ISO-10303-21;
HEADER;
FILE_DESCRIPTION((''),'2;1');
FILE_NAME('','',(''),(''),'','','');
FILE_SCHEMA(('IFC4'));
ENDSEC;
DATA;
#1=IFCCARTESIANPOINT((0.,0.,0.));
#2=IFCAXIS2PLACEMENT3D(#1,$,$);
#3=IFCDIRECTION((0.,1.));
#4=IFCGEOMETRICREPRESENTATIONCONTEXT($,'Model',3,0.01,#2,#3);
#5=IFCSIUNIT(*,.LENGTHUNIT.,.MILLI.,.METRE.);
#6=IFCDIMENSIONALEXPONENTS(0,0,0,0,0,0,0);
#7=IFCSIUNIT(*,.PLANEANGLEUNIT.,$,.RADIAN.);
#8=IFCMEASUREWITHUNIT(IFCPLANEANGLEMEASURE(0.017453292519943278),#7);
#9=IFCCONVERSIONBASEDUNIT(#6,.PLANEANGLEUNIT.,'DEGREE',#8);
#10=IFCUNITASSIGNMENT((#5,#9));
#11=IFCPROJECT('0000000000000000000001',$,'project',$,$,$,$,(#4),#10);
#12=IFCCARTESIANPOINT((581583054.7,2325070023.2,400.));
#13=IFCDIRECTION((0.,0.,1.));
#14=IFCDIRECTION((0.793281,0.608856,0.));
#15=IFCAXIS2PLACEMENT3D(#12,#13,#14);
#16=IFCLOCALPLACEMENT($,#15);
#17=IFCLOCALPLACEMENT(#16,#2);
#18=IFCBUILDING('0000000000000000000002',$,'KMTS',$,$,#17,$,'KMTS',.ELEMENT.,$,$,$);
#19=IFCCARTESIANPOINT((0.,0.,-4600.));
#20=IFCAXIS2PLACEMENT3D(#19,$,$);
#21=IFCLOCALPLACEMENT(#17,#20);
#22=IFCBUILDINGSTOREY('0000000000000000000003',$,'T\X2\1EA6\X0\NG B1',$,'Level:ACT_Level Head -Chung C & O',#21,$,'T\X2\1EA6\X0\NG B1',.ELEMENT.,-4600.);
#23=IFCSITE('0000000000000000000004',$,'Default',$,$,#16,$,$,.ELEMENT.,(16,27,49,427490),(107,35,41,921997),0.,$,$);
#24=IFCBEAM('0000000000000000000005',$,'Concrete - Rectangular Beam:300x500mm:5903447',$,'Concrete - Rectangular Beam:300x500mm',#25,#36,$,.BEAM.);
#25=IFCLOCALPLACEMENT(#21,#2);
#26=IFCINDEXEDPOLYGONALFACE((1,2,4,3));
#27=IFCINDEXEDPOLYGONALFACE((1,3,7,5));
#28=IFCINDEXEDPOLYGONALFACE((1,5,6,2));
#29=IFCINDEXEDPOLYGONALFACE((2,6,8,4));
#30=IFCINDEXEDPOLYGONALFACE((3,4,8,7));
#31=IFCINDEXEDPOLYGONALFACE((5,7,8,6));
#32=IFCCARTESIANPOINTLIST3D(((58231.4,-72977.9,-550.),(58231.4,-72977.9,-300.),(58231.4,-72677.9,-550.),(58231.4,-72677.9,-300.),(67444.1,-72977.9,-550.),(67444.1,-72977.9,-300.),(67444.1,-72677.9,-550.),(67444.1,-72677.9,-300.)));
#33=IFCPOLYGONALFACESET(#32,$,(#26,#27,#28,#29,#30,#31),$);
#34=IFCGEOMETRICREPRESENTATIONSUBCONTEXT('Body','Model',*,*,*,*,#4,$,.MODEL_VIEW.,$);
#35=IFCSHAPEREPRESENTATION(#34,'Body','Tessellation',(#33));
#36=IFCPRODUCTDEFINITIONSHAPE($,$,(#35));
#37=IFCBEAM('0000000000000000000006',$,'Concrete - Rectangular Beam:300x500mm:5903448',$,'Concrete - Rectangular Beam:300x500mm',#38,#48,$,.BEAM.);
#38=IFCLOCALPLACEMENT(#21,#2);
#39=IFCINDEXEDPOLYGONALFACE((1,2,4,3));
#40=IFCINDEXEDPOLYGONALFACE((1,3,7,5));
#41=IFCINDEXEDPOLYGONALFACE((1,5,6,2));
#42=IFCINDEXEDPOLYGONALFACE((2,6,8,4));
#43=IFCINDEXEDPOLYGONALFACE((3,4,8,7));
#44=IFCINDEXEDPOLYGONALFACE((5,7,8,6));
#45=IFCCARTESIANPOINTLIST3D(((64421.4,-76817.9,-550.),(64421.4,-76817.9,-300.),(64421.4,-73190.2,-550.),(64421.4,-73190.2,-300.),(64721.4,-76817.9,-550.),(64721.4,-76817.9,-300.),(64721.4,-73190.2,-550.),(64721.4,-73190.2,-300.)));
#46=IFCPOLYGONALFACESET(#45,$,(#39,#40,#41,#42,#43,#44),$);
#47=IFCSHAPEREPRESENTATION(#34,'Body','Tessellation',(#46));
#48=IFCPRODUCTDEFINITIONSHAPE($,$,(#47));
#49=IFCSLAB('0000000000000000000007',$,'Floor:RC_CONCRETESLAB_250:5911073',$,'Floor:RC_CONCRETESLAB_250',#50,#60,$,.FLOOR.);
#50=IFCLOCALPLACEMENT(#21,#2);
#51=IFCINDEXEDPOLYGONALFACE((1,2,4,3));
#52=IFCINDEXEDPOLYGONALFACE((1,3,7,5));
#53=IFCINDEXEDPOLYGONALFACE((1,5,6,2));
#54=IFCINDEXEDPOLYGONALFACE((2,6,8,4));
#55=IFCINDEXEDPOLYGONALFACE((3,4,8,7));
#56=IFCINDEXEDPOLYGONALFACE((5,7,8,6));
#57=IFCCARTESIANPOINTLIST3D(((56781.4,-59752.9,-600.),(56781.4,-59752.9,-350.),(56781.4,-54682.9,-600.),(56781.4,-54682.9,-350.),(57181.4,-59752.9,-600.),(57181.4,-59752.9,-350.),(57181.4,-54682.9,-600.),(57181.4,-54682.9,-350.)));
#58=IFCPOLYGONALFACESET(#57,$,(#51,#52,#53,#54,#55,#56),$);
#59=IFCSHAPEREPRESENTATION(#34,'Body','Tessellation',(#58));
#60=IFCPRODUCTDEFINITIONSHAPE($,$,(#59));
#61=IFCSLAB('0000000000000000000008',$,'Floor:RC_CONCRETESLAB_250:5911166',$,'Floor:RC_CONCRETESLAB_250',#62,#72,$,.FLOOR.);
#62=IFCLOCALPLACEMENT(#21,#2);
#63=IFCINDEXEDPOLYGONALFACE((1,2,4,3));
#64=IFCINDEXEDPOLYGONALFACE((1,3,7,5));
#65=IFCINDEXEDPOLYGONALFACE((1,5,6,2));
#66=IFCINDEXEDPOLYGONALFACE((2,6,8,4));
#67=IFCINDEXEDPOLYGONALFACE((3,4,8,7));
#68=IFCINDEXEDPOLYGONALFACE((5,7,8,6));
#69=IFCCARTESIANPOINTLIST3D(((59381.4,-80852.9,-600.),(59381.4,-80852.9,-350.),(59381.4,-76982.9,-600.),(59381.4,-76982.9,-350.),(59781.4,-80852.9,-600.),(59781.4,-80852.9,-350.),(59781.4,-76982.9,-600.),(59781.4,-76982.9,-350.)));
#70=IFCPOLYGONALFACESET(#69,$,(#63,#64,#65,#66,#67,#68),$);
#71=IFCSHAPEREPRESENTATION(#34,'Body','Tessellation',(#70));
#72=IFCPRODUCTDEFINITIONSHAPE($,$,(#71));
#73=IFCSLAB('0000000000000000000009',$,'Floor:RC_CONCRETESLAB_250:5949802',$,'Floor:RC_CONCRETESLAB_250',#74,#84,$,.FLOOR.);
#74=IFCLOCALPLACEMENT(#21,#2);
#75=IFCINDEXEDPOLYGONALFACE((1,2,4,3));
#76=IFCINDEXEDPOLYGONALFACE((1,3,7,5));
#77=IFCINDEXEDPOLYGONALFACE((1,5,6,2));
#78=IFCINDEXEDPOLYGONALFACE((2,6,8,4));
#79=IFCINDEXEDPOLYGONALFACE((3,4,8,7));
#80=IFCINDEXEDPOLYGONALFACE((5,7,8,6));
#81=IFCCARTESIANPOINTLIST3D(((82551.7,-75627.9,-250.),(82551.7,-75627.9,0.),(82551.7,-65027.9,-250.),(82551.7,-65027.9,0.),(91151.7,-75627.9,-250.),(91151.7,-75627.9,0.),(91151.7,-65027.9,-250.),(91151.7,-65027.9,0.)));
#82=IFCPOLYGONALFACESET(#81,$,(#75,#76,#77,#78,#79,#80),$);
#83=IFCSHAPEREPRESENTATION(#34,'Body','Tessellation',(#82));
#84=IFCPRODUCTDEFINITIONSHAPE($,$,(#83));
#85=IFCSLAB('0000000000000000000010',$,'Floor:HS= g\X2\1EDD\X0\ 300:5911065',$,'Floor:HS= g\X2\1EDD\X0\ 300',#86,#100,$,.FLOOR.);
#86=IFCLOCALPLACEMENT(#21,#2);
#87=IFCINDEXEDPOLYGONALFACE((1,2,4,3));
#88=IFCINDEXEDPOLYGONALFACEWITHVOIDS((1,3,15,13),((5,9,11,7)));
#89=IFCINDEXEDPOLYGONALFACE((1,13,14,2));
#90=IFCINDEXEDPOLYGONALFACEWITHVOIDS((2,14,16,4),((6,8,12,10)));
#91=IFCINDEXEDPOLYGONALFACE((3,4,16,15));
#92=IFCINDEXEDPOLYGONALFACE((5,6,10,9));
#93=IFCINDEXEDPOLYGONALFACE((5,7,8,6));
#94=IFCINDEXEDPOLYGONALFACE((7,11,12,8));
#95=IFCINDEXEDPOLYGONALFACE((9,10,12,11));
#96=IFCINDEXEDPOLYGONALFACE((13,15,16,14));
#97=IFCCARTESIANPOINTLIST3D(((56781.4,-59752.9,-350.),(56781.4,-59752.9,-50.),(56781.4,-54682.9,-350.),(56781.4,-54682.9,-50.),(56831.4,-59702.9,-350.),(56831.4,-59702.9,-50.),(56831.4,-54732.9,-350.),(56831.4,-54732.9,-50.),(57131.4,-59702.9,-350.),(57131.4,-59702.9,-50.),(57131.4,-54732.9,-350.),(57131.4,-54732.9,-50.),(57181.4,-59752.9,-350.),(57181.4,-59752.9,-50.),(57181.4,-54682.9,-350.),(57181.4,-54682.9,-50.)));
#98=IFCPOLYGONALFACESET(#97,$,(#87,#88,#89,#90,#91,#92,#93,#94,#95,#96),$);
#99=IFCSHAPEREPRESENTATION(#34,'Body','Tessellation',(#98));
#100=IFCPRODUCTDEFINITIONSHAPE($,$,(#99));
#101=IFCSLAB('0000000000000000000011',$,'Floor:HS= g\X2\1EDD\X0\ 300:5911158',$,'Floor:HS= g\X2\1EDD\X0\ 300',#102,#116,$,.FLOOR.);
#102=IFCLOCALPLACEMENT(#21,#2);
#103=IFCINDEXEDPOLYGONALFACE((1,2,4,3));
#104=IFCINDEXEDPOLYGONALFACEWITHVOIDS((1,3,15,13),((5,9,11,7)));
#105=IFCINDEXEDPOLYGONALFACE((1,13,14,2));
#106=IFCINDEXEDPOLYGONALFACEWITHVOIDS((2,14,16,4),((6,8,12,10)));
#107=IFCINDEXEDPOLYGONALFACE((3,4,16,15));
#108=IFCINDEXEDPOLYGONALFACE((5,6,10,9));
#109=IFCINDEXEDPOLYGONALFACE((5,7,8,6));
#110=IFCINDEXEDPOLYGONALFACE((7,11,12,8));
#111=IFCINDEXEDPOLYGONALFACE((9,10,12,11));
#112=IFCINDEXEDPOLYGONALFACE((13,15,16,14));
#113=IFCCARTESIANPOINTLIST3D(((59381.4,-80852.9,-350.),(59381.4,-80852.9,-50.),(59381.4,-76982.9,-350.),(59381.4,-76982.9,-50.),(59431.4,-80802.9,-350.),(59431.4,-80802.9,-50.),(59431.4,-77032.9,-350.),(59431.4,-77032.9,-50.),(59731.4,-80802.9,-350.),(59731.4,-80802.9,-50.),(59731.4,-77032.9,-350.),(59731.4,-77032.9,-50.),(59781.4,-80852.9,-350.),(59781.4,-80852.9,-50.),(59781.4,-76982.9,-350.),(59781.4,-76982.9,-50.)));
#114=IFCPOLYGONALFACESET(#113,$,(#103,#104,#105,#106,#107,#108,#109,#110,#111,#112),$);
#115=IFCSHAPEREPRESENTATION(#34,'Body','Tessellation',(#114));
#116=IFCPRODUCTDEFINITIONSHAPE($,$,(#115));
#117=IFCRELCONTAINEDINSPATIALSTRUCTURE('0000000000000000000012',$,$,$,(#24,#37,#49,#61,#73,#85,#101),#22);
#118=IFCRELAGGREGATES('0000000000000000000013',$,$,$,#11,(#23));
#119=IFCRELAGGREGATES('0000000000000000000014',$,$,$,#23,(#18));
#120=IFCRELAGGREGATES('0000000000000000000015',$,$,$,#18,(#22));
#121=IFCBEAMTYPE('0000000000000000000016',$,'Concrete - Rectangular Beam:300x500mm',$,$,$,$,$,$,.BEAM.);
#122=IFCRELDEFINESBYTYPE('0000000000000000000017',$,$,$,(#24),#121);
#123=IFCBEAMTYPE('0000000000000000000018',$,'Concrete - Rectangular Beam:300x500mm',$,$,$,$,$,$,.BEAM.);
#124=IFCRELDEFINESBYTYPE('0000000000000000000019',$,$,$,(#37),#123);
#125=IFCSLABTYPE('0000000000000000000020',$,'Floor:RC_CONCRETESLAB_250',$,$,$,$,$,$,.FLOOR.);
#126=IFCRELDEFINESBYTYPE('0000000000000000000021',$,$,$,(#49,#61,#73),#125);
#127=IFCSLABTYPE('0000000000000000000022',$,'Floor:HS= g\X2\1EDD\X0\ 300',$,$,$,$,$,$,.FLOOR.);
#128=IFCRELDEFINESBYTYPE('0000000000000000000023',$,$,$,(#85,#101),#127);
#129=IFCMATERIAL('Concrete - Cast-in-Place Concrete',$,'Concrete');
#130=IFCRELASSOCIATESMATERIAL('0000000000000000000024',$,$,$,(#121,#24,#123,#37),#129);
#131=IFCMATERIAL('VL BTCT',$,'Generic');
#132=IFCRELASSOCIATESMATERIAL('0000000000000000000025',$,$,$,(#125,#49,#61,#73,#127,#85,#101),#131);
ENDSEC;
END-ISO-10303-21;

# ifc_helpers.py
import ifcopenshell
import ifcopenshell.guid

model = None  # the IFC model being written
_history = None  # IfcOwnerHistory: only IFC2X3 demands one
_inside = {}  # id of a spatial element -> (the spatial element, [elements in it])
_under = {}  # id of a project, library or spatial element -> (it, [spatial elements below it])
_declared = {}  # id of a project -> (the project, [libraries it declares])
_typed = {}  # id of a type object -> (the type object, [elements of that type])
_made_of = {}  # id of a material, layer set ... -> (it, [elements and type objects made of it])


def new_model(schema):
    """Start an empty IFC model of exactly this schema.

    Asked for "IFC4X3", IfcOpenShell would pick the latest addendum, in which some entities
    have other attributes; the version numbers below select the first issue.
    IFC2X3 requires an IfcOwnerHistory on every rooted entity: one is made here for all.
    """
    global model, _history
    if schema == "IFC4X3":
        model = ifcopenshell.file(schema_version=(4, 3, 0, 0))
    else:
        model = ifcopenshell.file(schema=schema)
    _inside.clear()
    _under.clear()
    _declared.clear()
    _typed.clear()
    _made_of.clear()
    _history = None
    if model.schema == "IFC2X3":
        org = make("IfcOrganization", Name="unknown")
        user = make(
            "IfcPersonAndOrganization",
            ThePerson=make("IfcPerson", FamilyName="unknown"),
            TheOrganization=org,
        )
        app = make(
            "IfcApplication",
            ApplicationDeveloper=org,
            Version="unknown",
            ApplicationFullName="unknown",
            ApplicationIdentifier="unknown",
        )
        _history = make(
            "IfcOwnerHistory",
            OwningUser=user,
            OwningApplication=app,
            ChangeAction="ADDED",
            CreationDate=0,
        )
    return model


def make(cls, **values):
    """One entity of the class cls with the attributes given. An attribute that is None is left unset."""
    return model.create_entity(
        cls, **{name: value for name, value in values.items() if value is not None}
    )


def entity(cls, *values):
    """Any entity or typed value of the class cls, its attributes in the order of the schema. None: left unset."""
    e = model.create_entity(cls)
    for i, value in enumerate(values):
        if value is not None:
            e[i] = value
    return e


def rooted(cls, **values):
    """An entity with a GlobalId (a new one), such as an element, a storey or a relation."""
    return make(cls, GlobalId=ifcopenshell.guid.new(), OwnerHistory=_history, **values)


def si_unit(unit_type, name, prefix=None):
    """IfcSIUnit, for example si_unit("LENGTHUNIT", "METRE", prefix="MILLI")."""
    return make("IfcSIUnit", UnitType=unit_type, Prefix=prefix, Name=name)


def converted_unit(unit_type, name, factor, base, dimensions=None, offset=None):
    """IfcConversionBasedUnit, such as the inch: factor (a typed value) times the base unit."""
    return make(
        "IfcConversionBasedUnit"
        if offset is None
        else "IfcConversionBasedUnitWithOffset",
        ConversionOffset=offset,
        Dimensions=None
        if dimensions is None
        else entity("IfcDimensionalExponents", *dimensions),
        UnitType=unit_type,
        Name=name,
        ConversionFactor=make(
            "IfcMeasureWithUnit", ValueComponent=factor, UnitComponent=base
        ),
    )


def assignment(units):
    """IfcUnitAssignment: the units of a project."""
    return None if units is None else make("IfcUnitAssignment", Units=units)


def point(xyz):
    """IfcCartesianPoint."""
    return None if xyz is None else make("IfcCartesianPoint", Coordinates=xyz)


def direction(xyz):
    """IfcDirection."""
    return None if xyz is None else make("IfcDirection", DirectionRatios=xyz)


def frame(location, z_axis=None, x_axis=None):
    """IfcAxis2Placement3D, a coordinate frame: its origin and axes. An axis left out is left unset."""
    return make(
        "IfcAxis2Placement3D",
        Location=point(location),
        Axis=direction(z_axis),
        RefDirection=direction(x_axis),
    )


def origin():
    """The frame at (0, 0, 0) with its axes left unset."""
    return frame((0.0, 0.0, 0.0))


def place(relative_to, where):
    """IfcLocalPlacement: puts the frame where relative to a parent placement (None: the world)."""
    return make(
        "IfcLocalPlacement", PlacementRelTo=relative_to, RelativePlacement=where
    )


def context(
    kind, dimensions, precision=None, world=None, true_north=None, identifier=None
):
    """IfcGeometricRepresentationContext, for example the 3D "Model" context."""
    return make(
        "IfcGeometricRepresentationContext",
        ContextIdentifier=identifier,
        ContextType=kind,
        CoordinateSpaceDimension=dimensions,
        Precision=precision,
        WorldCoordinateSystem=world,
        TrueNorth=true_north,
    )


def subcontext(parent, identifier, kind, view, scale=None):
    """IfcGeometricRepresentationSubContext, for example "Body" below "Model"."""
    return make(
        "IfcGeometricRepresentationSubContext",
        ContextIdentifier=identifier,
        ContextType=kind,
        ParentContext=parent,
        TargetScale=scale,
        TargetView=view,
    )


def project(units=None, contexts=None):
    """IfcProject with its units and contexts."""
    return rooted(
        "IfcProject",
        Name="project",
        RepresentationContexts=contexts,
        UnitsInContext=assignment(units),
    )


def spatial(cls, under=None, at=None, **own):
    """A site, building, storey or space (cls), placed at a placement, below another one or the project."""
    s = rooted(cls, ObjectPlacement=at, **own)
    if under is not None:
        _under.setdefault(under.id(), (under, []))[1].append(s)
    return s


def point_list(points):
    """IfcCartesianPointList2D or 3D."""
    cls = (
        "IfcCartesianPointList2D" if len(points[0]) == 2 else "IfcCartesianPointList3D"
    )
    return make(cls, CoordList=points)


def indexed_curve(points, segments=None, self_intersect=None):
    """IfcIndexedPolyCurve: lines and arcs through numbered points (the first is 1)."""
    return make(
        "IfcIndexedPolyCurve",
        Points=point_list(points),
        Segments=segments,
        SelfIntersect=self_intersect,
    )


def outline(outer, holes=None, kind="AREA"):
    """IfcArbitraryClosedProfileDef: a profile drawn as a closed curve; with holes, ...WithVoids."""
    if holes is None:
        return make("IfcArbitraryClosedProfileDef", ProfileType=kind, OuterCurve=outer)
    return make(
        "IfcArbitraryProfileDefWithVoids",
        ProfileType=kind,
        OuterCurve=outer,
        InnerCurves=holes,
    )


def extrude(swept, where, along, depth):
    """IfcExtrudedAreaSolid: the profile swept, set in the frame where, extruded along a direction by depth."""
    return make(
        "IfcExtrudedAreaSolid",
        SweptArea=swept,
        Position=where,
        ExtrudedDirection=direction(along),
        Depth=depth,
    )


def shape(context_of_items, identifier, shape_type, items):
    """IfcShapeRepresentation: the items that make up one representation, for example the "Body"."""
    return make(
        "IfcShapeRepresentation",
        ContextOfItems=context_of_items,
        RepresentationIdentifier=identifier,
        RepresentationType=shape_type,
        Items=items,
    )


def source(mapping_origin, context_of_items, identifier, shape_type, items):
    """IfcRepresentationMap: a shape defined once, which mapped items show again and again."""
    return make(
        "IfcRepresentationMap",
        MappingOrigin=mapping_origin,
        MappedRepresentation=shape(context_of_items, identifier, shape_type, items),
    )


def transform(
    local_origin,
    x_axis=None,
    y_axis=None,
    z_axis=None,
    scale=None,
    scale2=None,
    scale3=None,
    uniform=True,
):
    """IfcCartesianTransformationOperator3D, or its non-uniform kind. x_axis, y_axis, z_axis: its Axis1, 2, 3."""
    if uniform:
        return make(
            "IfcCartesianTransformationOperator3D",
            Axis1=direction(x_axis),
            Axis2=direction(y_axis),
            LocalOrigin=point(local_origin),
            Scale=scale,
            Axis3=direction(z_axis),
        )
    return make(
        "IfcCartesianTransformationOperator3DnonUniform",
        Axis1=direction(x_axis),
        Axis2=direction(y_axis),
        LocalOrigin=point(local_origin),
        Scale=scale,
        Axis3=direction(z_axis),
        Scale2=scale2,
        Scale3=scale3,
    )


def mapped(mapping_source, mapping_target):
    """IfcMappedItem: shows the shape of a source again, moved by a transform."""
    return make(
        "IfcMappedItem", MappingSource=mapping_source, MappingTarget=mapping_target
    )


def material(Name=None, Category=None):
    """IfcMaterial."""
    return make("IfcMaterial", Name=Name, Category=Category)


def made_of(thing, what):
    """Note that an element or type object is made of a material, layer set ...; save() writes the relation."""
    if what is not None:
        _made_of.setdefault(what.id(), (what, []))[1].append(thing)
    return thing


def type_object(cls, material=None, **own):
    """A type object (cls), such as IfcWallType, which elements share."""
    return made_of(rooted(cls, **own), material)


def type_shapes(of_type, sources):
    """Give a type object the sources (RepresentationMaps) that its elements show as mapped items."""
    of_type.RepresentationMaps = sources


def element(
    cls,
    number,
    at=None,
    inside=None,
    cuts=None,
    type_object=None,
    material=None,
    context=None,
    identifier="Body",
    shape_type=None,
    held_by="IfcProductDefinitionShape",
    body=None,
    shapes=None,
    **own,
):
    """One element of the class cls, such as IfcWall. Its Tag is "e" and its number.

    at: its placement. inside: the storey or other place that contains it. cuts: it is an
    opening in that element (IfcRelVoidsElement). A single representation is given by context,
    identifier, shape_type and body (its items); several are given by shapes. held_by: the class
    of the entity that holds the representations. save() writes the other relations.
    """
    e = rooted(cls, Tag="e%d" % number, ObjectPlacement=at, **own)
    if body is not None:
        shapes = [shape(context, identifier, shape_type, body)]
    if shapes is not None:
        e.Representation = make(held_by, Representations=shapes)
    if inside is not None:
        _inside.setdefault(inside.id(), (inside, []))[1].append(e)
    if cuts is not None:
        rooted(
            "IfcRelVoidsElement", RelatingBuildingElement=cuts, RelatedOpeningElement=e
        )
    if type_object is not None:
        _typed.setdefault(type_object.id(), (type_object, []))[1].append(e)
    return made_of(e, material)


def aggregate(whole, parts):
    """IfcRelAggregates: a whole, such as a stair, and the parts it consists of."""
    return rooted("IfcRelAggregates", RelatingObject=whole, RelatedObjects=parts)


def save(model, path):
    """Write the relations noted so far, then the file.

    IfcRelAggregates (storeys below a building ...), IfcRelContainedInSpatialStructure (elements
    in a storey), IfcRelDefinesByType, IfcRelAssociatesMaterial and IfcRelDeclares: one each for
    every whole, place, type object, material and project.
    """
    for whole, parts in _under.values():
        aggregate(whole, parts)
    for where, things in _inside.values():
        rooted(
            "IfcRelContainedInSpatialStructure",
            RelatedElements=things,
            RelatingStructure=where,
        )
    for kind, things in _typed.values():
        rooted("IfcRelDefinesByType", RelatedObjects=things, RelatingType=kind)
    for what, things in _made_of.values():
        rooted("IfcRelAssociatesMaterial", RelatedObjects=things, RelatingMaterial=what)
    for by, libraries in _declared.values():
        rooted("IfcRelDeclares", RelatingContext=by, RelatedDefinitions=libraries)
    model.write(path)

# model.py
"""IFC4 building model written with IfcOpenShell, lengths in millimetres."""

from ifc_helpers import new_model, entity, si_unit, converted_unit, direction, frame, origin, place, context, subcontext, project, spatial, indexed_curve, outline, extrude, source, transform, mapped, material, type_object, type_shapes, element, save


model = new_model("IFC4")

# Units and contexts
model_context = context("Model", 3, precision=0.01, world=origin(), true_north=direction((0.0, 1.0)))
body_context = subcontext(model_context, "Body", "Model", "MODEL_VIEW")
ifc_project = project(units=[si_unit("LENGTHUNIT", "METRE", prefix="MILLI"), converted_unit("PLANEANGLEUNIT", "DEGREE", entity("IfcPlaneAngleMeasure", 0.017453292519943278), si_unit("PLANEANGLEUNIT", "RADIAN"), dimensions=[0, 0, 0, 0, 0, 0, 0])], contexts=[model_context])

# Site, building, storey
site_placement = place(None, frame((581583054.7, 2325070023.2, 400.0), z_axis=(0.0, 0.0, 1.0), x_axis=(0.793281, 0.608856, 0.0)))
site = spatial("IfcSite", under=ifc_project, at=site_placement, Name="Default", CompositionType="ELEMENT", RefLatitude=(16, 27, 49, 427490), RefLongitude=(107, 35, 41, 921997), RefElevation=0.0)
building_placement = place(site_placement, origin())
building = spatial("IfcBuilding", under=site, at=building_placement, Name="KMTS", LongName="KMTS", CompositionType="ELEMENT")
storey_placement = place(building_placement, frame((0.0, 0.0, -4600.0)))
storey = spatial("IfcBuildingStorey", under=building, at=storey_placement, Name="TẦNG B1", ObjectType="Level:ACT_Level Head -Chung C & O", LongName="TẦNG B1", CompositionType="ELEMENT", Elevation=-4600.0)

# Shared definitions
ifc_material_1 = material(Name="VL BTCT", Category="Generic")

# Beams
ifc_material_2 = material(Name="Concrete - Cast-in-Place Concrete", Category="Concrete")
beam_type_1 = type_object("IfcBeamType", Name="Concrete - Rectangular Beam:300x500mm", PredefinedType="BEAM", material=ifc_material_2)
shared_shape_1 = source(origin(), body_context, "Body", "SweptSolid", [
    extrude(outline(indexed_curve([(-125.0, -150.0), (125.0, -150.0), (125.0, 150.0), (-125.0, 150.0), (-125.0, -150.0)], self_intersect=False)), frame((58231.4, -72827.9, -5025.0), z_axis=(1.0, 0.0, 0.0), x_axis=(0.0, 0.0, -1.0)), (0.0, 0.0, 1.0), 9212.7),
])
type_shapes(beam_type_1, [shared_shape_1])
beam_1_placement = place(storey_placement, frame((0.0, 0.0, 4600.0)))
element("IfcBeam", 1, at=beam_1_placement, inside=storey, type_object=beam_type_1, material=ifc_material_2, Name="Concrete - Rectangular Beam:300x500mm:5903447", ObjectType="Concrete - Rectangular Beam:300x500mm", PredefinedType="BEAM", context=body_context, shape_type="MappedRepresentation", body=[
    mapped(shared_shape_1, transform((0.0, 0.0, 0.0), scale=1.0)),
])
beam_type_2 = type_object("IfcBeamType", Name="Concrete - Rectangular Beam:300x500mm", PredefinedType="BEAM", material=ifc_material_2)
shared_shape_2 = source(origin(), body_context, "Body", "SweptSolid", [
    extrude(outline(indexed_curve([(-150.0, -125.0), (150.0, -125.0), (150.0, 125.0), (-150.0, 125.0), (-150.0, -125.0)], self_intersect=False)), frame((64571.4, -73190.2, -5025.0), z_axis=(0.0, -1.0, 0.0), x_axis=(-1.0, 0.0, 0.0)), (0.0, 0.0, 1.0), 3627.7),
])
type_shapes(beam_type_2, [shared_shape_2])
beam_2_placement = place(storey_placement, frame((0.0, 0.0, 4600.0)))
element("IfcBeam", 2, at=beam_2_placement, inside=storey, type_object=beam_type_2, material=ifc_material_2, Name="Concrete - Rectangular Beam:300x500mm:5903448", ObjectType="Concrete - Rectangular Beam:300x500mm", PredefinedType="BEAM", context=body_context, shape_type="MappedRepresentation", body=[
    mapped(shared_shape_2, transform((0.0, 0.0, 0.0), scale=1.0)),
])

# Slabs
slab_type_1 = type_object("IfcSlabType", Name="Floor:RC_CONCRETESLAB_250", PredefinedType="FLOOR", material=ifc_material_1)
slab_1_placement = place(storey_placement, origin())
element("IfcSlab", 3, at=slab_1_placement, inside=storey, type_object=slab_type_1, material=ifc_material_1, Name="Floor:RC_CONCRETESLAB_250:5911073", ObjectType="Floor:RC_CONCRETESLAB_250", PredefinedType="FLOOR", context=body_context, shape_type="SweptSolid", body=[
    extrude(outline(indexed_curve([(-2535.0, -200.0), (2535.0, -200.0), (2535.0, 200.0), (-2535.0, 200.0), (-2535.0, -200.0)], self_intersect=False)), frame((56981.4, -57217.9, -350.0), z_axis=(0.0, 0.0, -1.0), x_axis=(0.0, 1.0, 0.0)), (0.0, 0.0, 1.0), 250.0),
])
slab_2_placement = place(storey_placement, origin())
element("IfcSlab", 4, at=slab_2_placement, inside=storey, type_object=slab_type_1, material=ifc_material_1, Name="Floor:RC_CONCRETESLAB_250:5911166", ObjectType="Floor:RC_CONCRETESLAB_250", PredefinedType="FLOOR", context=body_context, shape_type="SweptSolid", body=[
    extrude(outline(indexed_curve([(-1935.0, -200.0), (1935.0, -200.0), (1935.0, 200.0), (-1935.0, 200.0), (-1935.0, -200.0)], self_intersect=False)), frame((59581.4, -78917.9, -350.0), z_axis=(0.0, 0.0, -1.0), x_axis=(0.0, 1.0, 0.0)), (0.0, 0.0, 1.0), 250.0),
])
slab_3_placement = place(storey_placement, origin())
element("IfcSlab", 5, at=slab_3_placement, inside=storey, type_object=slab_type_1, material=ifc_material_1, Name="Floor:RC_CONCRETESLAB_250:5949802", ObjectType="Floor:RC_CONCRETESLAB_250", PredefinedType="FLOOR", context=body_context, shape_type="SweptSolid", body=[
    extrude(outline(indexed_curve([(-5300.0, -4300.0), (5300.0, -4300.0), (5300.0, 4300.0), (-5300.0, 4300.0), (-5300.0, -4300.0)], self_intersect=False)), frame((86851.7, -70327.9, 0.0), z_axis=(0.0, 0.0, -1.0), x_axis=(0.0, 1.0, 0.0)), (0.0, 0.0, 1.0), 250.0),
])

# Slabs, openings
slab_type_2 = type_object("IfcSlabType", Name="Floor:HS= gờ 300", PredefinedType="FLOOR", material=ifc_material_1)
slab_4_placement = place(storey_placement, origin())
slab_4 = element("IfcSlab", 6, at=slab_4_placement, inside=storey, type_object=slab_type_2, material=ifc_material_1, Name="Floor:HS= gờ 300:5911065", ObjectType="Floor:HS= gờ 300", PredefinedType="FLOOR", context=body_context, shape_type="SweptSolid", body=[
    extrude(outline(indexed_curve([(-2535.0, -200.0), (2535.0, -200.0), (2535.0, 200.0), (-2535.0, 200.0), (-2535.0, -200.0)], self_intersect=False), holes=[indexed_curve([(-2485.0, -150.0), (-2485.0, 150.0), (2485.0, 150.0), (2485.0, -150.0), (-2485.0, -150.0)], self_intersect=False)]), frame((56981.4, -57217.9, -350.0), z_axis=(0.0, 0.0, 1.0), x_axis=(0.0, -1.0, 0.0)), (0.0, 0.0, 1.0), 300.0),
])
opening_1_placement = place(slab_4_placement, origin())
element("IfcOpeningElement", 7, at=opening_1_placement, cuts=slab_4, PredefinedType="OPENING", context=body_context, shape_type="SweptSolid", body=[
    extrude(outline(indexed_curve([(-150.0, -2485.0), (150.0, -2485.0), (150.0, 2485.0), (-150.0, 2485.0), (-150.0, -2485.0)], self_intersect=False)), frame((56981.4, -57217.9, -50.0), z_axis=(0.0, 0.0, -1.0), x_axis=(1.0, 0.0, 0.0)), (0.0, 0.0, 1.0), 400.0),
])
slab_5_placement = place(storey_placement, origin())
slab_5 = element("IfcSlab", 8, at=slab_5_placement, inside=storey, type_object=slab_type_2, material=ifc_material_1, Name="Floor:HS= gờ 300:5911158", ObjectType="Floor:HS= gờ 300", PredefinedType="FLOOR", context=body_context, shape_type="SweptSolid", body=[
    extrude(outline(indexed_curve([(-1935.0, -200.0), (1935.0, -200.0), (1935.0, 200.0), (-1935.0, 200.0), (-1935.0, -200.0)], self_intersect=False), holes=[indexed_curve([(-1885.0, -150.0), (-1885.0, -100.0), (-1885.0, 150.0), (-1800.0, 150.0), (1885.0, 150.0), (1885.0, -150.0), (-1885.0, -150.0)], self_intersect=False)]), frame((59581.4, -78917.9, -350.0), z_axis=(0.0, 0.0, 1.0), x_axis=(0.0, -1.0, 0.0)), (0.0, 0.0, 1.0), 300.0),
])
opening_2_placement = place(slab_5_placement, origin())
element("IfcOpeningElement", 9, at=opening_2_placement, cuts=slab_5, PredefinedType="OPENING", context=body_context, shape_type="SweptSolid", body=[
    extrude(outline(indexed_curve([(-150.0, -1885.0), (150.0, -1885.0), (150.0, 1885.0), (-150.0, 1885.0), (-150.0, -1885.0)], self_intersect=False)), frame((59581.4, -78917.9, -50.0), z_axis=(0.0, 0.0, -1.0), x_axis=(1.0, 0.0, 0.0)), (0.0, 0.0, 1.0), 400.0),
])

save(model, "model.ifc")
